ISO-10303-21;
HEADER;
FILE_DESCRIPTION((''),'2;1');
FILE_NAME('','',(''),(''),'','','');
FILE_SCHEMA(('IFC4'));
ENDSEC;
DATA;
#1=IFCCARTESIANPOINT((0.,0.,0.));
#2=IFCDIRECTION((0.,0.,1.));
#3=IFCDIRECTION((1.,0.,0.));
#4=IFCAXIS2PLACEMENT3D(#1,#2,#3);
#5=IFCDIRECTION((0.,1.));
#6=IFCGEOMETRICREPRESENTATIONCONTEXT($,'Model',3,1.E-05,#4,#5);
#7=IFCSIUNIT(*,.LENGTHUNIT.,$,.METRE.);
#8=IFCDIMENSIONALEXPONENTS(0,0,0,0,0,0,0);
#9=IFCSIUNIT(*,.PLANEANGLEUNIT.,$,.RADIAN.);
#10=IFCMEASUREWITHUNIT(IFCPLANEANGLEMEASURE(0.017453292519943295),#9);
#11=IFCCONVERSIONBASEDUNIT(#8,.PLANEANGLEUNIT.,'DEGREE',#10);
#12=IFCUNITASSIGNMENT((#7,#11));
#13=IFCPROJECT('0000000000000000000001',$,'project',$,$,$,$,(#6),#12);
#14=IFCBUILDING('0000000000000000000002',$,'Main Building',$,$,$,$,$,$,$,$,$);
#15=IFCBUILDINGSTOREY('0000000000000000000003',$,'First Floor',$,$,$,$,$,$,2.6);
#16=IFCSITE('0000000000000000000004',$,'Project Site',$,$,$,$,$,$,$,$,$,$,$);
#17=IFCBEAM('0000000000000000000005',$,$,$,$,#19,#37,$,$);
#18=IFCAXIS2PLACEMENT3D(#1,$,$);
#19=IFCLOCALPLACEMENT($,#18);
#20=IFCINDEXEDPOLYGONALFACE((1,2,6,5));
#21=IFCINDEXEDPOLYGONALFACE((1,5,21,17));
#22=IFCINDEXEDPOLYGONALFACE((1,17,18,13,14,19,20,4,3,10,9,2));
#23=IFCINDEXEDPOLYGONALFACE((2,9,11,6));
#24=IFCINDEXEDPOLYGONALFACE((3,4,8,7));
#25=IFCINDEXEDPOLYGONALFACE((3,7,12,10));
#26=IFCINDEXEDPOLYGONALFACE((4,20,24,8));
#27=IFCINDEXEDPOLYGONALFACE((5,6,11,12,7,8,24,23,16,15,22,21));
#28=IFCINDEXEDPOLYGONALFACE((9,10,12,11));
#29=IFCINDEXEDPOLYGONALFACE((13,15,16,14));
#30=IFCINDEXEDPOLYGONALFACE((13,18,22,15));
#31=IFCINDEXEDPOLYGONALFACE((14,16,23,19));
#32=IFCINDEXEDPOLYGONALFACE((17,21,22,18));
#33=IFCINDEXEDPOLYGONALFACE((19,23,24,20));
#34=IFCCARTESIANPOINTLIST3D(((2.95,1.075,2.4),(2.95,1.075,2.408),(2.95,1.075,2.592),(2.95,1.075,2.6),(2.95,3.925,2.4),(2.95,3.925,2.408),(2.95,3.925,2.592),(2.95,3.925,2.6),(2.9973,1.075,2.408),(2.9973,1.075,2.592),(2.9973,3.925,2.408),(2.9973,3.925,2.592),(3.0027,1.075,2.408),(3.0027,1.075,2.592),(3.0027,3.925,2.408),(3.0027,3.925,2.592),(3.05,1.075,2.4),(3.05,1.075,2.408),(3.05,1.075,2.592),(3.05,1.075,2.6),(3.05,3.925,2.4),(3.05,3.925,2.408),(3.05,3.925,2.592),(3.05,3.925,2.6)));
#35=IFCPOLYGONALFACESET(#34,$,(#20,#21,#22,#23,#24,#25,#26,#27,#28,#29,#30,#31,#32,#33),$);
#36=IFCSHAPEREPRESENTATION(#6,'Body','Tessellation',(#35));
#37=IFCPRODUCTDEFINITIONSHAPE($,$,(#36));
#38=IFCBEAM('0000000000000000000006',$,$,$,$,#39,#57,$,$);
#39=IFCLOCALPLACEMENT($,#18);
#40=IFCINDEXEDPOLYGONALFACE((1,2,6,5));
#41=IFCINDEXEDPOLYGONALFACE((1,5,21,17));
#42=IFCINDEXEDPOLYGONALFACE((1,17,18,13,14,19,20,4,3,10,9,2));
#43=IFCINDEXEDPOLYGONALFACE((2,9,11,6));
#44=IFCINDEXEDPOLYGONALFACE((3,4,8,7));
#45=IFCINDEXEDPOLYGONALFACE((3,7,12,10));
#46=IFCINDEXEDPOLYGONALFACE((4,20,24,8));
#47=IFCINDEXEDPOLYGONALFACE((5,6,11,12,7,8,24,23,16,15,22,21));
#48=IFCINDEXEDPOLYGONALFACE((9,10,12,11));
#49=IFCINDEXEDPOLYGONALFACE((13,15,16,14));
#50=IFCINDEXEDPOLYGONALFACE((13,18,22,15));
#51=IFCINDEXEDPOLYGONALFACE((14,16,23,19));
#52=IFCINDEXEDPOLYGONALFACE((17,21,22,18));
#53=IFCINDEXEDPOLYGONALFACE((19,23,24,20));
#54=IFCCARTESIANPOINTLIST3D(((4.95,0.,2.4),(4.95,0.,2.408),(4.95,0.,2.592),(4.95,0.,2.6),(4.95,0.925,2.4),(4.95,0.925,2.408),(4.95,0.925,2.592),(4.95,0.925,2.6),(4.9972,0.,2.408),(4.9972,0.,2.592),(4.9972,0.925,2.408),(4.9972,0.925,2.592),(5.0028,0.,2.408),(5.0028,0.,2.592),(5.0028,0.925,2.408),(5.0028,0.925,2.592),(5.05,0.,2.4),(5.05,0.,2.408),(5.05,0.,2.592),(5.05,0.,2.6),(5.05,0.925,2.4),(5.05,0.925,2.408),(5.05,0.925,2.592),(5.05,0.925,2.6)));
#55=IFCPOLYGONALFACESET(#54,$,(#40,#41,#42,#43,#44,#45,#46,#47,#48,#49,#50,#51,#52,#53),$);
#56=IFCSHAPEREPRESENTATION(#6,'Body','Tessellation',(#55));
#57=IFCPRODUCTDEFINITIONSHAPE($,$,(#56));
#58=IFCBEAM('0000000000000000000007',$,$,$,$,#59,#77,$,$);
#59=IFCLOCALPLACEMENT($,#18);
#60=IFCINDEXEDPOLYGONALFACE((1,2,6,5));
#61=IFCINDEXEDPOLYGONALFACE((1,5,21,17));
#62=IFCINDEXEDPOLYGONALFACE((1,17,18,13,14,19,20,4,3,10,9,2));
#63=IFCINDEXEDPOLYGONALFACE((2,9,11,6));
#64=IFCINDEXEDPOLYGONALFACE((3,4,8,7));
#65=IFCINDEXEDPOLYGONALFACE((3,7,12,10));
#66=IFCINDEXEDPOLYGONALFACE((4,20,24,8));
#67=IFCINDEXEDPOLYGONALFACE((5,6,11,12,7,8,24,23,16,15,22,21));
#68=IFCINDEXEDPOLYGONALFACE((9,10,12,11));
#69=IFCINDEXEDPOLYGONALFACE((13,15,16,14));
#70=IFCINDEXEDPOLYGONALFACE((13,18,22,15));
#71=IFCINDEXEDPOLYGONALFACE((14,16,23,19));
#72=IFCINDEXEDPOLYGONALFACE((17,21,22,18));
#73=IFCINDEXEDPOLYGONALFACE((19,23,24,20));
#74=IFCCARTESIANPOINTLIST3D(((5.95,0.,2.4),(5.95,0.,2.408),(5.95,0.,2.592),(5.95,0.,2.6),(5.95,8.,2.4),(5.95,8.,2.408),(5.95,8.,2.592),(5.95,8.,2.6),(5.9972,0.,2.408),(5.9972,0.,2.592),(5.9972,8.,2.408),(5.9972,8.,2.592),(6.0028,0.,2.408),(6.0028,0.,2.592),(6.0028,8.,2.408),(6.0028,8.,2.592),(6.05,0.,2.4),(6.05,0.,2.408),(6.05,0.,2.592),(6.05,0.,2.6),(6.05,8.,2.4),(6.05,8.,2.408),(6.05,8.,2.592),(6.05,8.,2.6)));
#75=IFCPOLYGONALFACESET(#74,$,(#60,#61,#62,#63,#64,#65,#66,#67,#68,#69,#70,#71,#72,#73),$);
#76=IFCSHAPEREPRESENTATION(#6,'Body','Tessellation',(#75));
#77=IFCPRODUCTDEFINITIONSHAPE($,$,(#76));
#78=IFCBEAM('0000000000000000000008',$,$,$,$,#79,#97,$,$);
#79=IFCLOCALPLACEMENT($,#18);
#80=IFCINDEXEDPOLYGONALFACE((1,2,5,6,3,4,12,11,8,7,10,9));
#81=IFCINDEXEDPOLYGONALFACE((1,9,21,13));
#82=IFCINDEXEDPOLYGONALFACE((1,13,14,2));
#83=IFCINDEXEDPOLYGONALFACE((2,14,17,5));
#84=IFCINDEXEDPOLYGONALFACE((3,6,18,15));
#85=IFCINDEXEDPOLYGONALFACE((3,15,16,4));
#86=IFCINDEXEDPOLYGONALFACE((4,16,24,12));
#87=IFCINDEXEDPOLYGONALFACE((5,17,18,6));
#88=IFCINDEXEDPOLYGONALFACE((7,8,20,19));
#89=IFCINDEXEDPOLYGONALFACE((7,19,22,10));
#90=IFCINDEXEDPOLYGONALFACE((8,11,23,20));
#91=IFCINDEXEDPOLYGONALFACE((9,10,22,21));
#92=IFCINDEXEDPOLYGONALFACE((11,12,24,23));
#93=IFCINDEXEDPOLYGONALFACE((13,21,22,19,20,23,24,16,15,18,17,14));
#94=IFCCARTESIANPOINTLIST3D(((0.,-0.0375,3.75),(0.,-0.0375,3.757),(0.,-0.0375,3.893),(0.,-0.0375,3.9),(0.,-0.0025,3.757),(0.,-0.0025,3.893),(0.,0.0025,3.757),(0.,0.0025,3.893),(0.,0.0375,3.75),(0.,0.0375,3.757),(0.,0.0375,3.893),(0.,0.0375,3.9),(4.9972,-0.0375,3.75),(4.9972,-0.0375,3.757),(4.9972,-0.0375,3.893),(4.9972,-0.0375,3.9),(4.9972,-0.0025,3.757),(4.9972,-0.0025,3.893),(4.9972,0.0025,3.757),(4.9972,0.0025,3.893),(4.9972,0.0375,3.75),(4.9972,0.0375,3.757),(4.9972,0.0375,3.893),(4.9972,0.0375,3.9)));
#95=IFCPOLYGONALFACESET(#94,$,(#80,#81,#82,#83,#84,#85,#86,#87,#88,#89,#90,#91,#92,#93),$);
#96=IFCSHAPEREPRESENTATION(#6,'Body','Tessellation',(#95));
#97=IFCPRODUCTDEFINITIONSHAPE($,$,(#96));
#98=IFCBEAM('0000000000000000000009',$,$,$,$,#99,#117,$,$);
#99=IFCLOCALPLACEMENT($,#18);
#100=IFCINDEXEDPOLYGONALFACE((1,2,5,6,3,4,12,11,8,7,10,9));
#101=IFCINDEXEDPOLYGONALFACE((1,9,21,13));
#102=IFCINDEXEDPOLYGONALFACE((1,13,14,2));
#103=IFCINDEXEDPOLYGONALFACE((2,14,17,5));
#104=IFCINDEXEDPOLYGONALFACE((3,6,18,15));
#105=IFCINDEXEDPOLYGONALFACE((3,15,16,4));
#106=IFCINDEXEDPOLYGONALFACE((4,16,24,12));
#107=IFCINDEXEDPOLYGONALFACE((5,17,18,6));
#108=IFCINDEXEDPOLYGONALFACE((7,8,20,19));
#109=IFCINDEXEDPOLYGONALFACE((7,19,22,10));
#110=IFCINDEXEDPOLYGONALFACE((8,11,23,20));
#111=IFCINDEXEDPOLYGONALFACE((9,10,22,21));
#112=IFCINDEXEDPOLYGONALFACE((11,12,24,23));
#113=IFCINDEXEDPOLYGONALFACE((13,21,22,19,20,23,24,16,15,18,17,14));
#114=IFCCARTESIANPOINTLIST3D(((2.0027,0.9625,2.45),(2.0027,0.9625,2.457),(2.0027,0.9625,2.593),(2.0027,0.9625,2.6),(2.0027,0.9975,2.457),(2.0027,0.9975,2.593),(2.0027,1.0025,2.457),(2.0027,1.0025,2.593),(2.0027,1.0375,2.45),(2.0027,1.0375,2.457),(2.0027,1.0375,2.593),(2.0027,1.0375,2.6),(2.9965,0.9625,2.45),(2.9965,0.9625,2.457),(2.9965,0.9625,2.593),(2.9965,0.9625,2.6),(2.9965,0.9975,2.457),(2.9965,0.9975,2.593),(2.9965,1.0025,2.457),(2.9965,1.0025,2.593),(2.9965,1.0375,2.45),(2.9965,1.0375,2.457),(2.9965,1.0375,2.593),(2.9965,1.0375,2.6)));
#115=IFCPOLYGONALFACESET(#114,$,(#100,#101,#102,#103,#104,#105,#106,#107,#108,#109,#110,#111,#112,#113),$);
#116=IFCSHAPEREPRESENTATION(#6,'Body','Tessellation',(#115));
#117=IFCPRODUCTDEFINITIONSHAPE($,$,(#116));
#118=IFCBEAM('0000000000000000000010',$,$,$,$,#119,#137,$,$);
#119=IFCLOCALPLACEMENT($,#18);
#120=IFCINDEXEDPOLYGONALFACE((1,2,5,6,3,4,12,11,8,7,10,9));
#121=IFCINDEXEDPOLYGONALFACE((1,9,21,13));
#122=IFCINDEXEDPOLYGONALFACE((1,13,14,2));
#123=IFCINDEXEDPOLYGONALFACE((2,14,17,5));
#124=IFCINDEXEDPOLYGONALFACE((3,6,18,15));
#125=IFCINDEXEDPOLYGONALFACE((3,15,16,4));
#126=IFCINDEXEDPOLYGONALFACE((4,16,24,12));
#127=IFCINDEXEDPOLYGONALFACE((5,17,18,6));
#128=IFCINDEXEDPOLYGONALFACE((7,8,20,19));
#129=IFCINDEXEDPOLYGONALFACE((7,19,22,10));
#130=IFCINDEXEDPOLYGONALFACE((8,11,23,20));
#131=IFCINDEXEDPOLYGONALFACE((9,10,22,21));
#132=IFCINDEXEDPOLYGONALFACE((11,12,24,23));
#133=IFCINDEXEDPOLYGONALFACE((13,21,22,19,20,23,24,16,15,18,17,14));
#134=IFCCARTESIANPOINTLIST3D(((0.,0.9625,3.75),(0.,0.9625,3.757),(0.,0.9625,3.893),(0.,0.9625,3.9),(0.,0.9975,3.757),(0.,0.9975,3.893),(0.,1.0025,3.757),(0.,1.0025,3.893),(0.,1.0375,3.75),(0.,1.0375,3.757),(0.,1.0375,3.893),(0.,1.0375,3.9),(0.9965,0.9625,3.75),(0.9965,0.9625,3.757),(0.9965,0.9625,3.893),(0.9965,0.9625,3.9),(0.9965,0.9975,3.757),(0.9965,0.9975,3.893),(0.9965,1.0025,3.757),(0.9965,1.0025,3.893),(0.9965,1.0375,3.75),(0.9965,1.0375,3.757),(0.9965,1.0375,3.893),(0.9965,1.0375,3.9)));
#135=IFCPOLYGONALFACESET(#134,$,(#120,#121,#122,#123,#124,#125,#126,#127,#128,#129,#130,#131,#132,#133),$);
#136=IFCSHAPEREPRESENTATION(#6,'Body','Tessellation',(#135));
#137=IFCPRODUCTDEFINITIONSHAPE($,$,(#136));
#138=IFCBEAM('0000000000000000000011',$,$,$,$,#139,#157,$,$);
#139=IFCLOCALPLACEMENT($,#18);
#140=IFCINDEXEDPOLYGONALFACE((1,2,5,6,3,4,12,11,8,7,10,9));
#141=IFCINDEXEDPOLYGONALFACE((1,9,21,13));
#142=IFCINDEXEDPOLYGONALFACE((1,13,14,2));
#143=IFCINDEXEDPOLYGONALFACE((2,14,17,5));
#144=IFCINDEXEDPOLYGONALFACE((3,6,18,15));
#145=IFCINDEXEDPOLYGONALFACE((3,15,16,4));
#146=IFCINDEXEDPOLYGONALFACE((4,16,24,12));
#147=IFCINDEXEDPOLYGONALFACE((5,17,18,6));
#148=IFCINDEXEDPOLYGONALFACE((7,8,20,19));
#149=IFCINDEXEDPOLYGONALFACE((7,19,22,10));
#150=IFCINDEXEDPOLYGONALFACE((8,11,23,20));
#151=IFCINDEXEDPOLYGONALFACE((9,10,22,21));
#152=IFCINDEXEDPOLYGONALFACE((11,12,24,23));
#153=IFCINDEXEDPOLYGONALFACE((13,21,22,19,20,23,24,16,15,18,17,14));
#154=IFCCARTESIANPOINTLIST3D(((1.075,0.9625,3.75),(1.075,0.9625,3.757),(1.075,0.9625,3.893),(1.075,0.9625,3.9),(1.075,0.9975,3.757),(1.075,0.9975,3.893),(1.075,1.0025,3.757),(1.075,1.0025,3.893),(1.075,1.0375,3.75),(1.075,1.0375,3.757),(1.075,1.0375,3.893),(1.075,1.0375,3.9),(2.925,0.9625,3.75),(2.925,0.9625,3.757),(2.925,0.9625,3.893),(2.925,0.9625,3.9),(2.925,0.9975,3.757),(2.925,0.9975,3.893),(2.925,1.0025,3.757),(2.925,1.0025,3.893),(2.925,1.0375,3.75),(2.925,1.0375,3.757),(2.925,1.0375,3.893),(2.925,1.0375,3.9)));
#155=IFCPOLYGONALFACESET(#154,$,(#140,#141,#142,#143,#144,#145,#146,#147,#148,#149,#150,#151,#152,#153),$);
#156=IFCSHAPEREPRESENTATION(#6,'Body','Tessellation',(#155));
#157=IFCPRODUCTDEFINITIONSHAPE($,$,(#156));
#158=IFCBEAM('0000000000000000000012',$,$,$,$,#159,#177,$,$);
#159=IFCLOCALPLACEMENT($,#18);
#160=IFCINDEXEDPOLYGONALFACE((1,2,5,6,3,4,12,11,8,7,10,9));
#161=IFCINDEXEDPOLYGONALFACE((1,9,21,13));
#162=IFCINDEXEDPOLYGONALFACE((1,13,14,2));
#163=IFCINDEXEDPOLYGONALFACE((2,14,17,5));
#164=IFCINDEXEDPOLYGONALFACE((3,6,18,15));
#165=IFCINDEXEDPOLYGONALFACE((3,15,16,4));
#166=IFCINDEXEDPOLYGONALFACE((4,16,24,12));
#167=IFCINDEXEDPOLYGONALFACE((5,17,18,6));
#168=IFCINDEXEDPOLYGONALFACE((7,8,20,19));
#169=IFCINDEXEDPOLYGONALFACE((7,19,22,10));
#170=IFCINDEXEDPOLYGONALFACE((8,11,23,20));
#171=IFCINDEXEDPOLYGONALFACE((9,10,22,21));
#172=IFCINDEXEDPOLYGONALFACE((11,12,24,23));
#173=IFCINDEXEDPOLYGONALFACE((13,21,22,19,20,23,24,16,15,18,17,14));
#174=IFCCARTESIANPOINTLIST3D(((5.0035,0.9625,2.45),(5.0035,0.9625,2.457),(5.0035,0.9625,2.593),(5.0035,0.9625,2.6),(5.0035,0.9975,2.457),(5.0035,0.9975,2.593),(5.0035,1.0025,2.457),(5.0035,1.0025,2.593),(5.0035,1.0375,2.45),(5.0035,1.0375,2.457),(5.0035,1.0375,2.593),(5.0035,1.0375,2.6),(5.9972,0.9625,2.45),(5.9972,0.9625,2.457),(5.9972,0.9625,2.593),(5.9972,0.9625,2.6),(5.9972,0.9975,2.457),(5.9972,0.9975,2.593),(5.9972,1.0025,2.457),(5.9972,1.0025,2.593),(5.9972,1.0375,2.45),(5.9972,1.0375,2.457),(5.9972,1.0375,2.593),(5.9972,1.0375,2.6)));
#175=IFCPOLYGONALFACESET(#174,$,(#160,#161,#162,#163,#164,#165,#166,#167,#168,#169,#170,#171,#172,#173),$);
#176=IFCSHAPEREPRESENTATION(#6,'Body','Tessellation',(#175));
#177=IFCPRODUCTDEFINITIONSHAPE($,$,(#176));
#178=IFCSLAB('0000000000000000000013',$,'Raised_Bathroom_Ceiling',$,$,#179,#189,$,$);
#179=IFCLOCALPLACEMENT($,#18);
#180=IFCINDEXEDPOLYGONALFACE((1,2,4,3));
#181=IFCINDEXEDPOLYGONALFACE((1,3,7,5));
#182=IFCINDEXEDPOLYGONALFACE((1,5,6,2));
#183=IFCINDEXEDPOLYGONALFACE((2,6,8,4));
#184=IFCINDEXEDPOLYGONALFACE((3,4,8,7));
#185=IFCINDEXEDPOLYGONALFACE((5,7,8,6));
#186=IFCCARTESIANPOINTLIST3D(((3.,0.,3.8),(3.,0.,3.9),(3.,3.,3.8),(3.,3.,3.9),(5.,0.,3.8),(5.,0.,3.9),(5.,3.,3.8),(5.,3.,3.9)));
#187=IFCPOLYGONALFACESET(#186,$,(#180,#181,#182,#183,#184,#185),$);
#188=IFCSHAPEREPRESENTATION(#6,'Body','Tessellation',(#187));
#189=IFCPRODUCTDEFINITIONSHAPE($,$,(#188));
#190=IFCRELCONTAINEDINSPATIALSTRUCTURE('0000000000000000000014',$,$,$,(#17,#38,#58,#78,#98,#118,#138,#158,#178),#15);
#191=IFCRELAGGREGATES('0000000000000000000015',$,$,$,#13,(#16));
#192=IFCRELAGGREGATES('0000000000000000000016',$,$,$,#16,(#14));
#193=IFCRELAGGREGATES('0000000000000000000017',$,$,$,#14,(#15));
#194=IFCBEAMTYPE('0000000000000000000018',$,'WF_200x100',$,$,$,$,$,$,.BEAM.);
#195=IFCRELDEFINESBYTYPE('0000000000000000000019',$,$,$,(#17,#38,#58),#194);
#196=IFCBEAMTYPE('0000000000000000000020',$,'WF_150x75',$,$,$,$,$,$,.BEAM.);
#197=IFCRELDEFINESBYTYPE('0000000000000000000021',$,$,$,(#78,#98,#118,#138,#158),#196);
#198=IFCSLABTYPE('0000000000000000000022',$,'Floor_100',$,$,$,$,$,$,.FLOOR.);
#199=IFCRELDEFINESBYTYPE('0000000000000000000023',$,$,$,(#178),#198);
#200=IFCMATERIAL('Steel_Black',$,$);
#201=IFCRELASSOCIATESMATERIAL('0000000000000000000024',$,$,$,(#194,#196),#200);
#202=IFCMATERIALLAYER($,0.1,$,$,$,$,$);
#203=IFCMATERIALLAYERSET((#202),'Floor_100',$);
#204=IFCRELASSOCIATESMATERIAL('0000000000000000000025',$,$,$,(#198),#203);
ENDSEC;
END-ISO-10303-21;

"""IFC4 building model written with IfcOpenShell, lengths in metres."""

from ifc_helpers import new_model, entity, si_unit, converted_unit, direction, frame, frame_2d, origin, origin_with_axes, origin_2d, place, context, project, spatial, polyline, i_section, outline, extrude, material, layer, layer_set, material_profile, profile_set, type_object, element, save


model = new_model("IFC4")

# Units and contexts
model_context = context("Model", 3, precision=1e-05, world=origin_with_axes(), true_north=direction((0.0, 1.0)))
ifc_project = project(units=[si_unit("LENGTHUNIT", "METRE"), converted_unit("PLANEANGLEUNIT", "DEGREE", entity("IfcPlaneAngleMeasure", 0.017453292519943295), si_unit("PLANEANGLEUNIT", "RADIAN"), dimensions=[0, 0, 0, 0, 0, 0, 0])], contexts=[model_context])

# Site, building, storey
site = spatial("IfcSite", under=ifc_project, Name="Project Site")
building = spatial("IfcBuilding", under=site, Name="Main Building")
storey = spatial("IfcBuildingStorey", under=building, Name="First Floor", Elevation=2.6)

# Shared definitions
ifc_material_1 = material(Name="Steel_Black")

# Beams
ifc_material_profile_1 = material_profile(ifc_material_1, i_section(OverallWidth=0.1, OverallDepth=0.2, WebThickness=0.0055, FlangeThickness=0.008, at=origin_2d()), Name="WF_200x100")
ifc_profile_set_1 = profile_set([ifc_material_profile_1], Name="WF_200x100")
beam_type_1 = type_object("IfcBeamType", Name="WF_200x100", PredefinedType="BEAM", material=ifc_profile_set_1)
beam_1_placement = place(None, frame((3.0, 1.075, 2.4), z_axis=(0.0, 0.0, 1.0), x_axis=(0.0, 1.0, 0.0)))
element("IfcBeam", 1, at=beam_1_placement, inside=storey, type_object=beam_type_1, context=model_context, shape_type="SweptSolid", body=[
    extrude(i_section(OverallWidth=0.1, OverallDepth=0.2, WebThickness=0.0055, FlangeThickness=0.008, at=frame_2d((0.0, 0.1))), frame((0.0, 0.0, 0.0), z_axis=(1.0, 0.0, 0.0), x_axis=(0.0, 1.0, 0.0)), (0.0, 0.0, 1.0), 2.85),
])
beam_2_placement = place(None, frame((5.0, 0.0, 2.4), z_axis=(0.0, 0.0, 1.0), x_axis=(0.0, 1.0, 0.0)))
element("IfcBeam", 2, at=beam_2_placement, inside=storey, type_object=beam_type_1, context=model_context, shape_type="SweptSolid", body=[
    extrude(i_section(OverallWidth=0.1, OverallDepth=0.2, WebThickness=0.0055, FlangeThickness=0.008, at=frame_2d((0.0, 0.1))), frame((0.0, 0.0, 0.0), z_axis=(1.0, 0.0, 0.0), x_axis=(0.0, 1.0, 0.0)), (0.0, 0.0, 1.0), 0.925),
])
beam_3_placement = place(None, frame((6.0, 0.0, 2.4), z_axis=(0.0, 0.0, 1.0), x_axis=(0.0, 1.0, 0.0)))
element("IfcBeam", 3, at=beam_3_placement, inside=storey, type_object=beam_type_1, context=model_context, shape_type="SweptSolid", body=[
    extrude(i_section(OverallWidth=0.1, OverallDepth=0.2, WebThickness=0.0055, FlangeThickness=0.008, at=frame_2d((0.0, 0.1))), frame((0.0, 0.0, 0.0), z_axis=(1.0, 0.0, 0.0), x_axis=(0.0, 1.0, 0.0)), (0.0, 0.0, 1.0), 8.0),
])
ifc_material_profile_2 = material_profile(ifc_material_1, i_section(OverallWidth=0.075, OverallDepth=0.15, WebThickness=0.005, FlangeThickness=0.007, at=origin_2d()), Name="WF_150x75")
ifc_profile_set_2 = profile_set([ifc_material_profile_2], Name="WF_150x75")
beam_type_2 = type_object("IfcBeamType", Name="WF_150x75", PredefinedType="BEAM", material=ifc_profile_set_2)
beam_4_placement = place(None, frame((0.0, 0.0, 3.75), z_axis=(0.0, 0.0, 1.0), x_axis=(1.0, 0.0, 0.0)))
element("IfcBeam", 4, at=beam_4_placement, inside=storey, type_object=beam_type_2, context=model_context, shape_type="SweptSolid", body=[
    extrude(i_section(OverallWidth=0.075, OverallDepth=0.15, WebThickness=0.005, FlangeThickness=0.007, at=frame_2d((0.0, 0.075))), frame((0.0, 0.0, 0.0), z_axis=(1.0, 0.0, 0.0), x_axis=(0.0, 1.0, 0.0)), (0.0, 0.0, 1.0), 4.9973),
])
beam_5_placement = place(None, frame((2.0027, 1.0, 2.45), z_axis=(0.0, 0.0, 1.0), x_axis=(1.0, 0.0, 0.0)))
element("IfcBeam", 5, at=beam_5_placement, inside=storey, type_object=beam_type_2, context=model_context, shape_type="SweptSolid", body=[
    extrude(i_section(OverallWidth=0.075, OverallDepth=0.15, WebThickness=0.005, FlangeThickness=0.007, at=frame_2d((0.0, 0.075))), frame((0.0, 0.0, 0.0), z_axis=(1.0, 0.0, 0.0), x_axis=(0.0, 1.0, 0.0)), (0.0, 0.0, 1.0), 0.9938),
])
beam_6_placement = place(None, frame((0.0, 1.0, 3.75), z_axis=(0.0, 0.0, 1.0), x_axis=(1.0, 0.0, 0.0)))
element("IfcBeam", 6, at=beam_6_placement, inside=storey, type_object=beam_type_2, context=model_context, shape_type="SweptSolid", body=[
    extrude(i_section(OverallWidth=0.075, OverallDepth=0.15, WebThickness=0.005, FlangeThickness=0.007, at=frame_2d((0.0, 0.075))), frame((0.0, 0.0, 0.0), z_axis=(1.0, 0.0, 0.0), x_axis=(0.0, 1.0, 0.0)), (0.0, 0.0, 1.0), 0.9965),
])
beam_7_placement = place(None, frame((1.075, 1.0, 3.75), z_axis=(0.0, 0.0, 1.0), x_axis=(1.0, 0.0, 0.0)))
element("IfcBeam", 7, at=beam_7_placement, inside=storey, type_object=beam_type_2, context=model_context, shape_type="SweptSolid", body=[
    extrude(i_section(OverallWidth=0.075, OverallDepth=0.15, WebThickness=0.005, FlangeThickness=0.007, at=frame_2d((0.0, 0.075))), frame((0.0, 0.0, 0.0), z_axis=(1.0, 0.0, 0.0), x_axis=(0.0, 1.0, 0.0)), (0.0, 0.0, 1.0), 1.85),
])
beam_8_placement = place(None, frame((5.0035, 1.0, 2.45), z_axis=(0.0, 0.0, 1.0), x_axis=(1.0, 0.0, 0.0)))
element("IfcBeam", 8, at=beam_8_placement, inside=storey, type_object=beam_type_2, context=model_context, shape_type="SweptSolid", body=[
    extrude(i_section(OverallWidth=0.075, OverallDepth=0.15, WebThickness=0.005, FlangeThickness=0.007, at=frame_2d((0.0, 0.075))), frame((0.0, 0.0, 0.0), z_axis=(1.0, 0.0, 0.0), x_axis=(0.0, 1.0, 0.0)), (0.0, 0.0, 1.0), 0.9938),
])

# Slab
ifc_layer_1 = layer(None, 0.1)
ifc_layer_set_1 = layer_set([ifc_layer_1], Name="Floor_100")
slab_type_1 = type_object("IfcSlabType", Name="Floor_100", PredefinedType="FLOOR", material=ifc_layer_set_1)
slab_1_placement = place(None, frame((0.0, 0.0, 3.8), z_axis=(0.0, 0.0, 1.0), x_axis=(1.0, 0.0, 0.0)))
element("IfcSlab", 9, at=slab_1_placement, inside=storey, type_object=slab_type_1, Name="Raised_Bathroom_Ceiling", context=model_context, shape_type="SweptSolid", body=[
    extrude(outline(polyline([(3.0, 0.0), (5.0, 0.0), (5.0, 3.0), (3.0, 3.0), (3.0, 0.0)])), origin(), (0.0, 0.0, 1.0), 0.1),
])

save(model, "model.ifc")
